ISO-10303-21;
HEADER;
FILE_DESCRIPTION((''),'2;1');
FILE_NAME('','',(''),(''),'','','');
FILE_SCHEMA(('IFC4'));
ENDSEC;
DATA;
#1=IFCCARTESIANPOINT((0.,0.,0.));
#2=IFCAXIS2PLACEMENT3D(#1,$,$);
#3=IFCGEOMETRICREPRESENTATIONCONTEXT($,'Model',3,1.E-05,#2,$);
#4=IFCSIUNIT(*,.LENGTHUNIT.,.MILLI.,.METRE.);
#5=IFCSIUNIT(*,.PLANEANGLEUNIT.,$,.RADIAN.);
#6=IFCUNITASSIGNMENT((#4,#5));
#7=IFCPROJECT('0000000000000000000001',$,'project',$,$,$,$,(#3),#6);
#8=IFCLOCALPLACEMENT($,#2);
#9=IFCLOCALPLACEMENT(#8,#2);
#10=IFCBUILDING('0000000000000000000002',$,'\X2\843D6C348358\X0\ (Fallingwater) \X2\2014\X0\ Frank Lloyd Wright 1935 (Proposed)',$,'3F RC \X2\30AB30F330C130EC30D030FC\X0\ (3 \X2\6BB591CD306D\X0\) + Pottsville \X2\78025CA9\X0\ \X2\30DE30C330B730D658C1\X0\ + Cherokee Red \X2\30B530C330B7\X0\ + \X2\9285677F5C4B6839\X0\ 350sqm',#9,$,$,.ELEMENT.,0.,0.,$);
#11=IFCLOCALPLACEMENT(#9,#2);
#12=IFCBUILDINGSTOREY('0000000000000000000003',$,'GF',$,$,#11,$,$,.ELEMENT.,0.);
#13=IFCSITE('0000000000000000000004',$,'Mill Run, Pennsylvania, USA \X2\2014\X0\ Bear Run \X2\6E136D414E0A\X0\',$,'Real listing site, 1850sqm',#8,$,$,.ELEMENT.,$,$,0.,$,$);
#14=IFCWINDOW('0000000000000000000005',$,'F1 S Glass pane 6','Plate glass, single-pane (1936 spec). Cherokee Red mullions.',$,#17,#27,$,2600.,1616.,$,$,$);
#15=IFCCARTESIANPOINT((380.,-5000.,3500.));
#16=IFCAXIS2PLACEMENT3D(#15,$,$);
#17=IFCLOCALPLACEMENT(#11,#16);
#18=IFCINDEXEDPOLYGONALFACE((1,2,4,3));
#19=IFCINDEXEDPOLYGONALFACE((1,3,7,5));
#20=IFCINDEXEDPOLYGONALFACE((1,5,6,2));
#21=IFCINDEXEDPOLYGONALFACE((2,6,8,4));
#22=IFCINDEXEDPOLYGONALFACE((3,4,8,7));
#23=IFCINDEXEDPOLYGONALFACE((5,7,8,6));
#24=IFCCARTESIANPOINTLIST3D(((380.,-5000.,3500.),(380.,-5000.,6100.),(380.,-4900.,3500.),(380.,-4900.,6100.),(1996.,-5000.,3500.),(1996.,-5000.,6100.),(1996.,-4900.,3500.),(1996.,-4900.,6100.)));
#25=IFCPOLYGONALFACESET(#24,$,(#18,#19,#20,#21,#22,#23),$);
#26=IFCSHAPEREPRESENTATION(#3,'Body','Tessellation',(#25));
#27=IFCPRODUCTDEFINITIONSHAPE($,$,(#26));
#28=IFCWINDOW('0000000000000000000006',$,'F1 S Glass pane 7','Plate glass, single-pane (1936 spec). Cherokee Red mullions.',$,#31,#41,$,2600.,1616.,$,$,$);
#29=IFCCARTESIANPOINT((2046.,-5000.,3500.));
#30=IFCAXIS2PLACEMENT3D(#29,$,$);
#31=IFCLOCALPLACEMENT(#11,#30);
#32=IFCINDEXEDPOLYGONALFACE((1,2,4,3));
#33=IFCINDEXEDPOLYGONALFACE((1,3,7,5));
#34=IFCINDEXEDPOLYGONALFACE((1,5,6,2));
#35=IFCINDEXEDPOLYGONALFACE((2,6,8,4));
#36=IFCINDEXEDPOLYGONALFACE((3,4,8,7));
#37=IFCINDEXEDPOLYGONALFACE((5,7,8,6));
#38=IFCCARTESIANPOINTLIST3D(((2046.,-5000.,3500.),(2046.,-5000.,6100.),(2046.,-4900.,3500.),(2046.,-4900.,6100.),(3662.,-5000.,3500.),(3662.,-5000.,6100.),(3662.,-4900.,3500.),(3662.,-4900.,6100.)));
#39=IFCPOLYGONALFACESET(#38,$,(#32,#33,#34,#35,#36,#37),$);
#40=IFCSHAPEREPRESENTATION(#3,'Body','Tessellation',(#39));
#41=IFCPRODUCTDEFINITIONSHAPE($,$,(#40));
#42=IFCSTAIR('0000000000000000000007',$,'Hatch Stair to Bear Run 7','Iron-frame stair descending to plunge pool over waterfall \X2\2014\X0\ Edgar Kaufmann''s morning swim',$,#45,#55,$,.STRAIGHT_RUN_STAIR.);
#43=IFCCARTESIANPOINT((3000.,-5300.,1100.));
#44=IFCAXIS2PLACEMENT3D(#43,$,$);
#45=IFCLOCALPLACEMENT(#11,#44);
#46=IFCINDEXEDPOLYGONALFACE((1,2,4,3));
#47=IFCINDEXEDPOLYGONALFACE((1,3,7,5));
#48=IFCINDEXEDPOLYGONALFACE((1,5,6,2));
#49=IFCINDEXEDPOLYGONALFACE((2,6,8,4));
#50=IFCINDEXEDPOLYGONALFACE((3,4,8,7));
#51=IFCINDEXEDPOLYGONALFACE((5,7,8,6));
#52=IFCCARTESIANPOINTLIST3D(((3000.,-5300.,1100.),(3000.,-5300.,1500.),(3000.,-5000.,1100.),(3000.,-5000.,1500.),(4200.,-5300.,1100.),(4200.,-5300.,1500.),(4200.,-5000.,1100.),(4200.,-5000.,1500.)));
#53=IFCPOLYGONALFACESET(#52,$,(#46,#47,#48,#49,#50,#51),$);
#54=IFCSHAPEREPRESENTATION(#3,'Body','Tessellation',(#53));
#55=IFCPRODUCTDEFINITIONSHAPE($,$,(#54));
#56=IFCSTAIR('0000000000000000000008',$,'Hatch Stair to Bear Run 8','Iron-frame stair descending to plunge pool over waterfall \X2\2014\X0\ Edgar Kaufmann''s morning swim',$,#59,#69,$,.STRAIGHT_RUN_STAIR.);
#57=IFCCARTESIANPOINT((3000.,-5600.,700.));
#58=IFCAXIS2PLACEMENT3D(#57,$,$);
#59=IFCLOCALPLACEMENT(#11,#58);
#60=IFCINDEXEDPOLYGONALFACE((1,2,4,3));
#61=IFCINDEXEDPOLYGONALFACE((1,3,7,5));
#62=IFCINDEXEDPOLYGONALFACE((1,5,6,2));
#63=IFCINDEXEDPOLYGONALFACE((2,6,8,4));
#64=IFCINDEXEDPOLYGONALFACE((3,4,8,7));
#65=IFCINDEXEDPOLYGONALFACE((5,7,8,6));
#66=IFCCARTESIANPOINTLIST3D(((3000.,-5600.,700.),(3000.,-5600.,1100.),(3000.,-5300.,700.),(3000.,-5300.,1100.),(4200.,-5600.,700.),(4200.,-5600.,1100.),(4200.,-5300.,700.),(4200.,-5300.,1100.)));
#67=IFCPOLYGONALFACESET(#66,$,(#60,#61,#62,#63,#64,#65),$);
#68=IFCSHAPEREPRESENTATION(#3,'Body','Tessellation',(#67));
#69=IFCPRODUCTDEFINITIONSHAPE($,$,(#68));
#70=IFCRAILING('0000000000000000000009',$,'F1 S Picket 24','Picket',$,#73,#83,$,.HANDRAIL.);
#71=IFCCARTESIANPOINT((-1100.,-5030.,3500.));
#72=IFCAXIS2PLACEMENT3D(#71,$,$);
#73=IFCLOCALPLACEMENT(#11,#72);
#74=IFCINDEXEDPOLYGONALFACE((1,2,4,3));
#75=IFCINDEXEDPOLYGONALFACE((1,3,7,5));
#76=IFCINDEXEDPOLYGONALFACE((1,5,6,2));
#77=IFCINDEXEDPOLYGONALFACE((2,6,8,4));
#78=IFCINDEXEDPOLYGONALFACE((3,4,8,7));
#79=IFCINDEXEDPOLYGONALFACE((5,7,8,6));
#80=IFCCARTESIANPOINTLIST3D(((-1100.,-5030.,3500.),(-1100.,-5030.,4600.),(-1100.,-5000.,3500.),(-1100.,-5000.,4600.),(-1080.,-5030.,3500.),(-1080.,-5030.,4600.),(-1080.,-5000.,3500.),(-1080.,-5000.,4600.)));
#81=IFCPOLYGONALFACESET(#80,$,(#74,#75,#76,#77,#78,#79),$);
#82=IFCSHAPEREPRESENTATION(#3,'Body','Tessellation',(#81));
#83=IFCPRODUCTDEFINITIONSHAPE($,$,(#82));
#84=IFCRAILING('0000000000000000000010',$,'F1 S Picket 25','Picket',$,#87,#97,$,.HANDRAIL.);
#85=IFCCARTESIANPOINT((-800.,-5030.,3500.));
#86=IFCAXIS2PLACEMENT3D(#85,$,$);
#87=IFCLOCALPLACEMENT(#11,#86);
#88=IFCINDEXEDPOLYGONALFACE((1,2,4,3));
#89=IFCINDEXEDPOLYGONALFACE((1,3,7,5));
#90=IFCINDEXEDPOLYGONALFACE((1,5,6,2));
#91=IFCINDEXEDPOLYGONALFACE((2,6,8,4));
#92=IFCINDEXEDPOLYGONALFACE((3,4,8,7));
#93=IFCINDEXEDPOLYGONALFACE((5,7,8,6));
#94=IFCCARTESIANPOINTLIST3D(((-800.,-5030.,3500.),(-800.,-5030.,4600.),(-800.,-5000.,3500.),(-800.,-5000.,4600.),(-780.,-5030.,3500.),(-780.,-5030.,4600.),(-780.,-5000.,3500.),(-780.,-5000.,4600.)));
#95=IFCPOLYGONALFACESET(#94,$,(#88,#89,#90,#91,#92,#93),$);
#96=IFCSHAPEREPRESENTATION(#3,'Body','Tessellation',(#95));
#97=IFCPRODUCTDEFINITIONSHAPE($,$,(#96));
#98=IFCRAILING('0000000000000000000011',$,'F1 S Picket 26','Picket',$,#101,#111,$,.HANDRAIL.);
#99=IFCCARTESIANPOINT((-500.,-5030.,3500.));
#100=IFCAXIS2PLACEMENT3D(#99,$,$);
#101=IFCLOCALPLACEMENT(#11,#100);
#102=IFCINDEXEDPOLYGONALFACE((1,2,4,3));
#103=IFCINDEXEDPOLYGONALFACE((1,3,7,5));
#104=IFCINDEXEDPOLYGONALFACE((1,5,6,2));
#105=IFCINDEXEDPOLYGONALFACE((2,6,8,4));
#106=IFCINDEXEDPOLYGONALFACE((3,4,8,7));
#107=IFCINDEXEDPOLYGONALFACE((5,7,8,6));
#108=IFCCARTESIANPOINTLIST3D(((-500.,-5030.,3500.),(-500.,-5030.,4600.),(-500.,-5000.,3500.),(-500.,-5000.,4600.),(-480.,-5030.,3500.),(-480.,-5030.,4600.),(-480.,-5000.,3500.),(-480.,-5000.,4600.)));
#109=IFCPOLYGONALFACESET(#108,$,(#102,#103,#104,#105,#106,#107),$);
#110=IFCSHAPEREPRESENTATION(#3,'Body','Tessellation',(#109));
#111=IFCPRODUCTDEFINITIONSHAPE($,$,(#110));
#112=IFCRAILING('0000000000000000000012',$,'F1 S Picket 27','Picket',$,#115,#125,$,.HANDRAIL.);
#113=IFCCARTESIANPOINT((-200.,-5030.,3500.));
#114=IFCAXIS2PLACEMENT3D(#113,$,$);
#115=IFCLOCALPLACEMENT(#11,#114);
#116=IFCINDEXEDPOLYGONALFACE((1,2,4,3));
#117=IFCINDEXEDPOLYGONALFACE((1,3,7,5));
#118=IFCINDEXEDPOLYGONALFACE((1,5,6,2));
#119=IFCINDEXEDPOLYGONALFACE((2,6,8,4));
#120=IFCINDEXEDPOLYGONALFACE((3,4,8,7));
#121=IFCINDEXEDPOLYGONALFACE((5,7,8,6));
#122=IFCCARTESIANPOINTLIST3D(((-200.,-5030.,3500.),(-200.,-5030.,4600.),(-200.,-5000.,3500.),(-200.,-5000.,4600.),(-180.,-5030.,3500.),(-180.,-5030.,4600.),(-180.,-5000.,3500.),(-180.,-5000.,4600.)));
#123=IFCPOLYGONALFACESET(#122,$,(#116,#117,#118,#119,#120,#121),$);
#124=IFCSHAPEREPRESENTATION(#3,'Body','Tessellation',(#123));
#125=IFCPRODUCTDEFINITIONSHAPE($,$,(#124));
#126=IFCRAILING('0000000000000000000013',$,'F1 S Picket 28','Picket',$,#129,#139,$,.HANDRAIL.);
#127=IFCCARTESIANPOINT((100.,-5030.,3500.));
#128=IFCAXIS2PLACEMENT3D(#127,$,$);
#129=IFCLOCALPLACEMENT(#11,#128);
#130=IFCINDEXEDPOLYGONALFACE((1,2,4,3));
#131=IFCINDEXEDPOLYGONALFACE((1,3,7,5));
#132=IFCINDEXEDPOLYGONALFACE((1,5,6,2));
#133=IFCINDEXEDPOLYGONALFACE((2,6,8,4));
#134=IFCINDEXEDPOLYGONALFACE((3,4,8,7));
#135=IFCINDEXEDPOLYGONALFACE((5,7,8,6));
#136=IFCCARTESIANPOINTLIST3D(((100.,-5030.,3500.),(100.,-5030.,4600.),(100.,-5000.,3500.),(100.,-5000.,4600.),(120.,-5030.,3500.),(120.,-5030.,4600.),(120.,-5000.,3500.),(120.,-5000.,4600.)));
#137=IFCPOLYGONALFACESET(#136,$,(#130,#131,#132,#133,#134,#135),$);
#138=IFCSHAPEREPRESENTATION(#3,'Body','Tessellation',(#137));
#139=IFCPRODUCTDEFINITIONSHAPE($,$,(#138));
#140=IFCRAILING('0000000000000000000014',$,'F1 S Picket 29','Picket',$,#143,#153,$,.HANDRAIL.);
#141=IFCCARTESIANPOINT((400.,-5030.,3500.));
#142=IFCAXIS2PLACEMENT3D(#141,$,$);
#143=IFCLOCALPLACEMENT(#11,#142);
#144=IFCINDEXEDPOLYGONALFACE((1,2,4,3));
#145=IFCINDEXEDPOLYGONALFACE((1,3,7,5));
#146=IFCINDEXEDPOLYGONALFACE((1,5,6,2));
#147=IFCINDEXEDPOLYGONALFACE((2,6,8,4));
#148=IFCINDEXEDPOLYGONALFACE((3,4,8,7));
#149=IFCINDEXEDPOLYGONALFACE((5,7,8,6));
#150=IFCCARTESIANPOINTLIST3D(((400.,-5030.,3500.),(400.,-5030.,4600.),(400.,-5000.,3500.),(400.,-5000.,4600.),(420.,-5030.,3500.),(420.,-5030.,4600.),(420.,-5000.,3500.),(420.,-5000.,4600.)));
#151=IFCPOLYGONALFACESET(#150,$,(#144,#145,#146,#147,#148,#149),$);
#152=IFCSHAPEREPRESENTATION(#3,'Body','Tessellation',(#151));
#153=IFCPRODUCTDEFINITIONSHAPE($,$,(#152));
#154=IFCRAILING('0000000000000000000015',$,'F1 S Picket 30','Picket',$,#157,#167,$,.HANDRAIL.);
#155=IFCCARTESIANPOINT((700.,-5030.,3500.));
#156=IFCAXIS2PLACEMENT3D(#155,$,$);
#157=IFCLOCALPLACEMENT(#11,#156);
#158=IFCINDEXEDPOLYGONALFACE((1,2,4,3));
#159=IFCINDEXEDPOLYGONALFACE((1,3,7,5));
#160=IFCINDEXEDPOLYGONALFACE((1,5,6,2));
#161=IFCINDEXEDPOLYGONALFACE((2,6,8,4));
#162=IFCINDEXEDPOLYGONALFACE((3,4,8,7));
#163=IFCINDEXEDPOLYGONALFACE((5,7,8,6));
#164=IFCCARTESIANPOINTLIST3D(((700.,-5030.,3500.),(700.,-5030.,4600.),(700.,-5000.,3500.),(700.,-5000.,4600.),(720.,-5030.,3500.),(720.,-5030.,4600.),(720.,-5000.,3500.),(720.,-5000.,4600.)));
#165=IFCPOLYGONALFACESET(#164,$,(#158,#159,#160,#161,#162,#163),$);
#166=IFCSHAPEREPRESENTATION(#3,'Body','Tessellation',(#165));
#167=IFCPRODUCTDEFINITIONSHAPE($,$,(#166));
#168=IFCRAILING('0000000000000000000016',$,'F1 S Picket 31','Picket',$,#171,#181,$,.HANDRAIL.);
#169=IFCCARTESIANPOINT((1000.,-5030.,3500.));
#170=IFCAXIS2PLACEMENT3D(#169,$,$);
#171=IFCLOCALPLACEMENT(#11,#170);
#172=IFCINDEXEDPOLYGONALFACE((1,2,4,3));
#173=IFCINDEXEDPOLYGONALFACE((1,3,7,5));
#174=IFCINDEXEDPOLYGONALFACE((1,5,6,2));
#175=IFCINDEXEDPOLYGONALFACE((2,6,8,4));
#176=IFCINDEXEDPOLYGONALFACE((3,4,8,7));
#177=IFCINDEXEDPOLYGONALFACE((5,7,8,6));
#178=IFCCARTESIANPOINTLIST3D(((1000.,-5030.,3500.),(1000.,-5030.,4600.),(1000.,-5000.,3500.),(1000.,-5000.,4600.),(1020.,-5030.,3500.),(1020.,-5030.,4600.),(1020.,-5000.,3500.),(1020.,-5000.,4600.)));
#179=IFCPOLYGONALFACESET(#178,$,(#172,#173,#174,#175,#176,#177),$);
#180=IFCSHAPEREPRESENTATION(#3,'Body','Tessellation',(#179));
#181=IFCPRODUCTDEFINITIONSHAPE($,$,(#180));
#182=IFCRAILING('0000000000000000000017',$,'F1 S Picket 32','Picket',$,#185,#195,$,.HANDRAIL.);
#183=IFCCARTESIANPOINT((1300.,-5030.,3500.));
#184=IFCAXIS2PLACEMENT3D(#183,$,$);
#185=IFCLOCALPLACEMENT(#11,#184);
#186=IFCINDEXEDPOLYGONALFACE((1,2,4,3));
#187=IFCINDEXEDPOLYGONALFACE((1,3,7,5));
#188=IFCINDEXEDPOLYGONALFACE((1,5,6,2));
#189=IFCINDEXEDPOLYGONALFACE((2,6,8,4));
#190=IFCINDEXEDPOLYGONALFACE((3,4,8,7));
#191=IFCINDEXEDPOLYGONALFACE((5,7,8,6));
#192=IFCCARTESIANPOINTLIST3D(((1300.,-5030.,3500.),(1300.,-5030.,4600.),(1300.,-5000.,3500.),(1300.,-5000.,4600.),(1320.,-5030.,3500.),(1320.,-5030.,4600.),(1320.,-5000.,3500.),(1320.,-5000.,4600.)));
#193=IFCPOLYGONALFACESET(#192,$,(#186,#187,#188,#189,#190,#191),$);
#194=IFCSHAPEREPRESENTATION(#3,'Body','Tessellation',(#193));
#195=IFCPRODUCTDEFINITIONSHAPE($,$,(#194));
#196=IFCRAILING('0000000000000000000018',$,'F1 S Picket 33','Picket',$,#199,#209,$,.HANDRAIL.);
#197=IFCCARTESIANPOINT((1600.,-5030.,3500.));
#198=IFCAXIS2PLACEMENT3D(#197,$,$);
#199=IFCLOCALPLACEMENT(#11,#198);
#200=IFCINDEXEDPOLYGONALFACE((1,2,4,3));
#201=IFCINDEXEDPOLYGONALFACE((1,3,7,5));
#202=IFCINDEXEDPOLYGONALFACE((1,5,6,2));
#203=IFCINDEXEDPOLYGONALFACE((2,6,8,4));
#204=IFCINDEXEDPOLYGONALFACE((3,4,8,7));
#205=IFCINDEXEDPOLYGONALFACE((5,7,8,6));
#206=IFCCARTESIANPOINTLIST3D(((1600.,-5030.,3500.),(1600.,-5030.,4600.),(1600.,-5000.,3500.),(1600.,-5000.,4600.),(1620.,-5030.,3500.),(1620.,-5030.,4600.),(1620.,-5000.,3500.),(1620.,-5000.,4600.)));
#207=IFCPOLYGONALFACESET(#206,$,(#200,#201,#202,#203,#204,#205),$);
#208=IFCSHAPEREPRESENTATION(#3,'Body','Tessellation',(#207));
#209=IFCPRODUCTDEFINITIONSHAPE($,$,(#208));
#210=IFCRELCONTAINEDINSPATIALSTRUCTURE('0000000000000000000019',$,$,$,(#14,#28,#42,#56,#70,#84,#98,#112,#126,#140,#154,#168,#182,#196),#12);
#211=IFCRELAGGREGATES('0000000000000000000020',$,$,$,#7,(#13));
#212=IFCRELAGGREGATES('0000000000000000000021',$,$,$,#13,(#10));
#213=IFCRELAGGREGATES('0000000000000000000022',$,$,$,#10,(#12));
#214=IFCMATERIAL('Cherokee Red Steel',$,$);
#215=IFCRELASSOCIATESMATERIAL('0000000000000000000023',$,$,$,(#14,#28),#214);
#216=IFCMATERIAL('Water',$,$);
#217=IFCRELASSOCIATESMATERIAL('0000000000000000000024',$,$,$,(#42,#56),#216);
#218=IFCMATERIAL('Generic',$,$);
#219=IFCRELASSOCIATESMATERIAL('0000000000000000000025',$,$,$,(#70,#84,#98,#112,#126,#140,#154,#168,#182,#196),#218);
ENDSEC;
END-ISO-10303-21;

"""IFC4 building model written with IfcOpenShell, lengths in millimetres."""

from ifc_helpers import new_model, si_unit, frame, frame_2d, origin, place, context, project, spatial, rectangle, extrude, material, element, save


model = new_model("IFC4")

# Units and contexts
model_context = context("Model", 3, precision=1e-05, world=origin())
ifc_project = project(units=[si_unit("LENGTHUNIT", "METRE", prefix="MILLI"), si_unit("PLANEANGLEUNIT", "RADIAN")], contexts=[model_context])

# Site, building, storey
site_placement = place(None, origin())
site = spatial("IfcSite", under=ifc_project, at=site_placement, Name="Mill Run, Pennsylvania, USA — Bear Run 渓流上", ObjectType="Real listing site, 1850sqm", CompositionType="ELEMENT", RefElevation=0.0)
building_placement = place(site_placement, origin())
building = spatial("IfcBuilding", under=site, at=building_placement, Name="落水荘 (Fallingwater) — Frank Lloyd Wright 1935 (Proposed)", ObjectType="3F RC カンチレバー (3 段重ね) + Pottsville 砂岩 マッシブ壁 + Cherokee Red サッシ + 銅板屋根 350sqm", CompositionType="ELEMENT", ElevationOfRefHeight=0.0, ElevationOfTerrain=0.0)
storey_placement = place(building_placement, origin())
storey = spatial("IfcBuildingStorey", under=building, at=storey_placement, Name="GF", CompositionType="ELEMENT", Elevation=0.0)

# Windows
ifc_material_1 = material(Name="Cherokee Red Steel")
window_1_placement = place(storey_placement, frame((380.0, -5000.0, 3500.0)))
element("IfcWindow", 1, at=window_1_placement, inside=storey, material=ifc_material_1, Name="F1 S Glass pane 6", Description="Plate glass, single-pane (1936 spec). Cherokee Red mullions.", OverallHeight=2600.0, OverallWidth=1616.0, context=model_context, shape_type="SweptSolid", body=[
    extrude(rectangle(XDim=1616.0, YDim=100.0, at=frame_2d((808.0, 50.0))), frame((380.0, -5000.0, 3500.0)), (0.0, 0.0, 1.0), 2600.0),
])
window_2_placement = place(storey_placement, frame((2046.0, -5000.0, 3500.0)))
element("IfcWindow", 2, at=window_2_placement, inside=storey, material=ifc_material_1, Name="F1 S Glass pane 7", Description="Plate glass, single-pane (1936 spec). Cherokee Red mullions.", OverallHeight=2600.0, OverallWidth=1616.0, context=model_context, shape_type="SweptSolid", body=[
    extrude(rectangle(XDim=1616.0, YDim=100.0, at=frame_2d((808.0, 50.0))), frame((2046.0, -5000.0, 3500.0)), (0.0, 0.0, 1.0), 2600.0),
])

# Stairs
ifc_material_2 = material(Name="Water")
stair_1_placement = place(storey_placement, frame((3000.0, -5300.0, 1100.0)))
element("IfcStair", 3, at=stair_1_placement, inside=storey, material=ifc_material_2, Name="Hatch Stair to Bear Run 7", Description="Iron-frame stair descending to plunge pool over waterfall — Edgar Kaufmann's morning swim", PredefinedType="STRAIGHT_RUN_STAIR", context=model_context, shape_type="SweptSolid", body=[
    extrude(rectangle(XDim=1200.0, YDim=300.0, at=frame_2d((600.0, 150.0))), frame((3000.0, -5300.0, 1100.0)), (0.0, 0.0, 1.0), 400.0),
])
stair_2_placement = place(storey_placement, frame((3000.0, -5600.0, 700.0)))
element("IfcStair", 4, at=stair_2_placement, inside=storey, material=ifc_material_2, Name="Hatch Stair to Bear Run 8", Description="Iron-frame stair descending to plunge pool over waterfall — Edgar Kaufmann's morning swim", PredefinedType="STRAIGHT_RUN_STAIR", context=model_context, shape_type="SweptSolid", body=[
    extrude(rectangle(XDim=1200.0, YDim=300.0, at=frame_2d((600.0, 150.0))), frame((3000.0, -5600.0, 700.0)), (0.0, 0.0, 1.0), 400.0),
])

# Railings
ifc_material_3 = material(Name="Generic")
railing_1_placement = place(storey_placement, frame((-1100.0, -5030.0, 3500.0)))
element("IfcRailing", 5, at=railing_1_placement, inside=storey, material=ifc_material_3, Name="F1 S Picket 24", Description="Picket", PredefinedType="HANDRAIL", context=model_context, shape_type="SweptSolid", body=[
    extrude(rectangle(XDim=20.0, YDim=30.0, at=frame_2d((10.0, 15.0))), frame((-1100.0, -5030.0, 3500.0)), (0.0, 0.0, 1.0), 1100.0),
])
railing_2_placement = place(storey_placement, frame((-800.0, -5030.0, 3500.0)))
element("IfcRailing", 6, at=railing_2_placement, inside=storey, material=ifc_material_3, Name="F1 S Picket 25", Description="Picket", PredefinedType="HANDRAIL", context=model_context, shape_type="SweptSolid", body=[
    extrude(rectangle(XDim=20.0, YDim=30.0, at=frame_2d((10.0, 15.0))), frame((-800.0, -5030.0, 3500.0)), (0.0, 0.0, 1.0), 1100.0),
])
railing_3_placement = place(storey_placement, frame((-500.0, -5030.0, 3500.0)))
element("IfcRailing", 7, at=railing_3_placement, inside=storey, material=ifc_material_3, Name="F1 S Picket 26", Description="Picket", PredefinedType="HANDRAIL", context=model_context, shape_type="SweptSolid", body=[
    extrude(rectangle(XDim=20.0, YDim=30.0, at=frame_2d((10.0, 15.0))), frame((-500.0, -5030.0, 3500.0)), (0.0, 0.0, 1.0), 1100.0),
])
railing_4_placement = place(storey_placement, frame((-200.0, -5030.0, 3500.0)))
element("IfcRailing", 8, at=railing_4_placement, inside=storey, material=ifc_material_3, Name="F1 S Picket 27", Description="Picket", PredefinedType="HANDRAIL", context=model_context, shape_type="SweptSolid", body=[
    extrude(rectangle(XDim=20.0, YDim=30.0, at=frame_2d((10.0, 15.0))), frame((-200.0, -5030.0, 3500.0)), (0.0, 0.0, 1.0), 1100.0),
])
railing_5_placement = place(storey_placement, frame((100.0, -5030.0, 3500.0)))
element("IfcRailing", 9, at=railing_5_placement, inside=storey, material=ifc_material_3, Name="F1 S Picket 28", Description="Picket", PredefinedType="HANDRAIL", context=model_context, shape_type="SweptSolid", body=[
    extrude(rectangle(XDim=20.0, YDim=30.0, at=frame_2d((10.0, 15.0))), frame((100.0, -5030.0, 3500.0)), (0.0, 0.0, 1.0), 1100.0),
])
railing_6_placement = place(storey_placement, frame((400.0, -5030.0, 3500.0)))
element("IfcRailing", 10, at=railing_6_placement, inside=storey, material=ifc_material_3, Name="F1 S Picket 29", Description="Picket", PredefinedType="HANDRAIL", context=model_context, shape_type="SweptSolid", body=[
    extrude(rectangle(XDim=20.0, YDim=30.0, at=frame_2d((10.0, 15.0))), frame((400.0, -5030.0, 3500.0)), (0.0, 0.0, 1.0), 1100.0),
])
railing_7_placement = place(storey_placement, frame((700.0, -5030.0, 3500.0)))
element("IfcRailing", 11, at=railing_7_placement, inside=storey, material=ifc_material_3, Name="F1 S Picket 30", Description="Picket", PredefinedType="HANDRAIL", context=model_context, shape_type="SweptSolid", body=[
    extrude(rectangle(XDim=20.0, YDim=30.0, at=frame_2d((10.0, 15.0))), frame((700.0, -5030.0, 3500.0)), (0.0, 0.0, 1.0), 1100.0),
])
railing_8_placement = place(storey_placement, frame((1000.0, -5030.0, 3500.0)))
element("IfcRailing", 12, at=railing_8_placement, inside=storey, material=ifc_material_3, Name="F1 S Picket 31", Description="Picket", PredefinedType="HANDRAIL", context=model_context, shape_type="SweptSolid", body=[
    extrude(rectangle(XDim=20.0, YDim=30.0, at=frame_2d((10.0, 15.0))), frame((1000.0, -5030.0, 3500.0)), (0.0, 0.0, 1.0), 1100.0),
])
railing_9_placement = place(storey_placement, frame((1300.0, -5030.0, 3500.0)))
element("IfcRailing", 13, at=railing_9_placement, inside=storey, material=ifc_material_3, Name="F1 S Picket 32", Description="Picket", PredefinedType="HANDRAIL", context=model_context, shape_type="SweptSolid", body=[
    extrude(rectangle(XDim=20.0, YDim=30.0, at=frame_2d((10.0, 15.0))), frame((1300.0, -5030.0, 3500.0)), (0.0, 0.0, 1.0), 1100.0),
])
railing_10_placement = place(storey_placement, frame((1600.0, -5030.0, 3500.0)))
element("IfcRailing", 14, at=railing_10_placement, inside=storey, material=ifc_material_3, Name="F1 S Picket 33", Description="Picket", PredefinedType="HANDRAIL", context=model_context, shape_type="SweptSolid", body=[
    extrude(rectangle(XDim=20.0, YDim=30.0, at=frame_2d((10.0, 15.0))), frame((1600.0, -5030.0, 3500.0)), (0.0, 0.0, 1.0), 1100.0),
])

save(model, "model.ifc")
